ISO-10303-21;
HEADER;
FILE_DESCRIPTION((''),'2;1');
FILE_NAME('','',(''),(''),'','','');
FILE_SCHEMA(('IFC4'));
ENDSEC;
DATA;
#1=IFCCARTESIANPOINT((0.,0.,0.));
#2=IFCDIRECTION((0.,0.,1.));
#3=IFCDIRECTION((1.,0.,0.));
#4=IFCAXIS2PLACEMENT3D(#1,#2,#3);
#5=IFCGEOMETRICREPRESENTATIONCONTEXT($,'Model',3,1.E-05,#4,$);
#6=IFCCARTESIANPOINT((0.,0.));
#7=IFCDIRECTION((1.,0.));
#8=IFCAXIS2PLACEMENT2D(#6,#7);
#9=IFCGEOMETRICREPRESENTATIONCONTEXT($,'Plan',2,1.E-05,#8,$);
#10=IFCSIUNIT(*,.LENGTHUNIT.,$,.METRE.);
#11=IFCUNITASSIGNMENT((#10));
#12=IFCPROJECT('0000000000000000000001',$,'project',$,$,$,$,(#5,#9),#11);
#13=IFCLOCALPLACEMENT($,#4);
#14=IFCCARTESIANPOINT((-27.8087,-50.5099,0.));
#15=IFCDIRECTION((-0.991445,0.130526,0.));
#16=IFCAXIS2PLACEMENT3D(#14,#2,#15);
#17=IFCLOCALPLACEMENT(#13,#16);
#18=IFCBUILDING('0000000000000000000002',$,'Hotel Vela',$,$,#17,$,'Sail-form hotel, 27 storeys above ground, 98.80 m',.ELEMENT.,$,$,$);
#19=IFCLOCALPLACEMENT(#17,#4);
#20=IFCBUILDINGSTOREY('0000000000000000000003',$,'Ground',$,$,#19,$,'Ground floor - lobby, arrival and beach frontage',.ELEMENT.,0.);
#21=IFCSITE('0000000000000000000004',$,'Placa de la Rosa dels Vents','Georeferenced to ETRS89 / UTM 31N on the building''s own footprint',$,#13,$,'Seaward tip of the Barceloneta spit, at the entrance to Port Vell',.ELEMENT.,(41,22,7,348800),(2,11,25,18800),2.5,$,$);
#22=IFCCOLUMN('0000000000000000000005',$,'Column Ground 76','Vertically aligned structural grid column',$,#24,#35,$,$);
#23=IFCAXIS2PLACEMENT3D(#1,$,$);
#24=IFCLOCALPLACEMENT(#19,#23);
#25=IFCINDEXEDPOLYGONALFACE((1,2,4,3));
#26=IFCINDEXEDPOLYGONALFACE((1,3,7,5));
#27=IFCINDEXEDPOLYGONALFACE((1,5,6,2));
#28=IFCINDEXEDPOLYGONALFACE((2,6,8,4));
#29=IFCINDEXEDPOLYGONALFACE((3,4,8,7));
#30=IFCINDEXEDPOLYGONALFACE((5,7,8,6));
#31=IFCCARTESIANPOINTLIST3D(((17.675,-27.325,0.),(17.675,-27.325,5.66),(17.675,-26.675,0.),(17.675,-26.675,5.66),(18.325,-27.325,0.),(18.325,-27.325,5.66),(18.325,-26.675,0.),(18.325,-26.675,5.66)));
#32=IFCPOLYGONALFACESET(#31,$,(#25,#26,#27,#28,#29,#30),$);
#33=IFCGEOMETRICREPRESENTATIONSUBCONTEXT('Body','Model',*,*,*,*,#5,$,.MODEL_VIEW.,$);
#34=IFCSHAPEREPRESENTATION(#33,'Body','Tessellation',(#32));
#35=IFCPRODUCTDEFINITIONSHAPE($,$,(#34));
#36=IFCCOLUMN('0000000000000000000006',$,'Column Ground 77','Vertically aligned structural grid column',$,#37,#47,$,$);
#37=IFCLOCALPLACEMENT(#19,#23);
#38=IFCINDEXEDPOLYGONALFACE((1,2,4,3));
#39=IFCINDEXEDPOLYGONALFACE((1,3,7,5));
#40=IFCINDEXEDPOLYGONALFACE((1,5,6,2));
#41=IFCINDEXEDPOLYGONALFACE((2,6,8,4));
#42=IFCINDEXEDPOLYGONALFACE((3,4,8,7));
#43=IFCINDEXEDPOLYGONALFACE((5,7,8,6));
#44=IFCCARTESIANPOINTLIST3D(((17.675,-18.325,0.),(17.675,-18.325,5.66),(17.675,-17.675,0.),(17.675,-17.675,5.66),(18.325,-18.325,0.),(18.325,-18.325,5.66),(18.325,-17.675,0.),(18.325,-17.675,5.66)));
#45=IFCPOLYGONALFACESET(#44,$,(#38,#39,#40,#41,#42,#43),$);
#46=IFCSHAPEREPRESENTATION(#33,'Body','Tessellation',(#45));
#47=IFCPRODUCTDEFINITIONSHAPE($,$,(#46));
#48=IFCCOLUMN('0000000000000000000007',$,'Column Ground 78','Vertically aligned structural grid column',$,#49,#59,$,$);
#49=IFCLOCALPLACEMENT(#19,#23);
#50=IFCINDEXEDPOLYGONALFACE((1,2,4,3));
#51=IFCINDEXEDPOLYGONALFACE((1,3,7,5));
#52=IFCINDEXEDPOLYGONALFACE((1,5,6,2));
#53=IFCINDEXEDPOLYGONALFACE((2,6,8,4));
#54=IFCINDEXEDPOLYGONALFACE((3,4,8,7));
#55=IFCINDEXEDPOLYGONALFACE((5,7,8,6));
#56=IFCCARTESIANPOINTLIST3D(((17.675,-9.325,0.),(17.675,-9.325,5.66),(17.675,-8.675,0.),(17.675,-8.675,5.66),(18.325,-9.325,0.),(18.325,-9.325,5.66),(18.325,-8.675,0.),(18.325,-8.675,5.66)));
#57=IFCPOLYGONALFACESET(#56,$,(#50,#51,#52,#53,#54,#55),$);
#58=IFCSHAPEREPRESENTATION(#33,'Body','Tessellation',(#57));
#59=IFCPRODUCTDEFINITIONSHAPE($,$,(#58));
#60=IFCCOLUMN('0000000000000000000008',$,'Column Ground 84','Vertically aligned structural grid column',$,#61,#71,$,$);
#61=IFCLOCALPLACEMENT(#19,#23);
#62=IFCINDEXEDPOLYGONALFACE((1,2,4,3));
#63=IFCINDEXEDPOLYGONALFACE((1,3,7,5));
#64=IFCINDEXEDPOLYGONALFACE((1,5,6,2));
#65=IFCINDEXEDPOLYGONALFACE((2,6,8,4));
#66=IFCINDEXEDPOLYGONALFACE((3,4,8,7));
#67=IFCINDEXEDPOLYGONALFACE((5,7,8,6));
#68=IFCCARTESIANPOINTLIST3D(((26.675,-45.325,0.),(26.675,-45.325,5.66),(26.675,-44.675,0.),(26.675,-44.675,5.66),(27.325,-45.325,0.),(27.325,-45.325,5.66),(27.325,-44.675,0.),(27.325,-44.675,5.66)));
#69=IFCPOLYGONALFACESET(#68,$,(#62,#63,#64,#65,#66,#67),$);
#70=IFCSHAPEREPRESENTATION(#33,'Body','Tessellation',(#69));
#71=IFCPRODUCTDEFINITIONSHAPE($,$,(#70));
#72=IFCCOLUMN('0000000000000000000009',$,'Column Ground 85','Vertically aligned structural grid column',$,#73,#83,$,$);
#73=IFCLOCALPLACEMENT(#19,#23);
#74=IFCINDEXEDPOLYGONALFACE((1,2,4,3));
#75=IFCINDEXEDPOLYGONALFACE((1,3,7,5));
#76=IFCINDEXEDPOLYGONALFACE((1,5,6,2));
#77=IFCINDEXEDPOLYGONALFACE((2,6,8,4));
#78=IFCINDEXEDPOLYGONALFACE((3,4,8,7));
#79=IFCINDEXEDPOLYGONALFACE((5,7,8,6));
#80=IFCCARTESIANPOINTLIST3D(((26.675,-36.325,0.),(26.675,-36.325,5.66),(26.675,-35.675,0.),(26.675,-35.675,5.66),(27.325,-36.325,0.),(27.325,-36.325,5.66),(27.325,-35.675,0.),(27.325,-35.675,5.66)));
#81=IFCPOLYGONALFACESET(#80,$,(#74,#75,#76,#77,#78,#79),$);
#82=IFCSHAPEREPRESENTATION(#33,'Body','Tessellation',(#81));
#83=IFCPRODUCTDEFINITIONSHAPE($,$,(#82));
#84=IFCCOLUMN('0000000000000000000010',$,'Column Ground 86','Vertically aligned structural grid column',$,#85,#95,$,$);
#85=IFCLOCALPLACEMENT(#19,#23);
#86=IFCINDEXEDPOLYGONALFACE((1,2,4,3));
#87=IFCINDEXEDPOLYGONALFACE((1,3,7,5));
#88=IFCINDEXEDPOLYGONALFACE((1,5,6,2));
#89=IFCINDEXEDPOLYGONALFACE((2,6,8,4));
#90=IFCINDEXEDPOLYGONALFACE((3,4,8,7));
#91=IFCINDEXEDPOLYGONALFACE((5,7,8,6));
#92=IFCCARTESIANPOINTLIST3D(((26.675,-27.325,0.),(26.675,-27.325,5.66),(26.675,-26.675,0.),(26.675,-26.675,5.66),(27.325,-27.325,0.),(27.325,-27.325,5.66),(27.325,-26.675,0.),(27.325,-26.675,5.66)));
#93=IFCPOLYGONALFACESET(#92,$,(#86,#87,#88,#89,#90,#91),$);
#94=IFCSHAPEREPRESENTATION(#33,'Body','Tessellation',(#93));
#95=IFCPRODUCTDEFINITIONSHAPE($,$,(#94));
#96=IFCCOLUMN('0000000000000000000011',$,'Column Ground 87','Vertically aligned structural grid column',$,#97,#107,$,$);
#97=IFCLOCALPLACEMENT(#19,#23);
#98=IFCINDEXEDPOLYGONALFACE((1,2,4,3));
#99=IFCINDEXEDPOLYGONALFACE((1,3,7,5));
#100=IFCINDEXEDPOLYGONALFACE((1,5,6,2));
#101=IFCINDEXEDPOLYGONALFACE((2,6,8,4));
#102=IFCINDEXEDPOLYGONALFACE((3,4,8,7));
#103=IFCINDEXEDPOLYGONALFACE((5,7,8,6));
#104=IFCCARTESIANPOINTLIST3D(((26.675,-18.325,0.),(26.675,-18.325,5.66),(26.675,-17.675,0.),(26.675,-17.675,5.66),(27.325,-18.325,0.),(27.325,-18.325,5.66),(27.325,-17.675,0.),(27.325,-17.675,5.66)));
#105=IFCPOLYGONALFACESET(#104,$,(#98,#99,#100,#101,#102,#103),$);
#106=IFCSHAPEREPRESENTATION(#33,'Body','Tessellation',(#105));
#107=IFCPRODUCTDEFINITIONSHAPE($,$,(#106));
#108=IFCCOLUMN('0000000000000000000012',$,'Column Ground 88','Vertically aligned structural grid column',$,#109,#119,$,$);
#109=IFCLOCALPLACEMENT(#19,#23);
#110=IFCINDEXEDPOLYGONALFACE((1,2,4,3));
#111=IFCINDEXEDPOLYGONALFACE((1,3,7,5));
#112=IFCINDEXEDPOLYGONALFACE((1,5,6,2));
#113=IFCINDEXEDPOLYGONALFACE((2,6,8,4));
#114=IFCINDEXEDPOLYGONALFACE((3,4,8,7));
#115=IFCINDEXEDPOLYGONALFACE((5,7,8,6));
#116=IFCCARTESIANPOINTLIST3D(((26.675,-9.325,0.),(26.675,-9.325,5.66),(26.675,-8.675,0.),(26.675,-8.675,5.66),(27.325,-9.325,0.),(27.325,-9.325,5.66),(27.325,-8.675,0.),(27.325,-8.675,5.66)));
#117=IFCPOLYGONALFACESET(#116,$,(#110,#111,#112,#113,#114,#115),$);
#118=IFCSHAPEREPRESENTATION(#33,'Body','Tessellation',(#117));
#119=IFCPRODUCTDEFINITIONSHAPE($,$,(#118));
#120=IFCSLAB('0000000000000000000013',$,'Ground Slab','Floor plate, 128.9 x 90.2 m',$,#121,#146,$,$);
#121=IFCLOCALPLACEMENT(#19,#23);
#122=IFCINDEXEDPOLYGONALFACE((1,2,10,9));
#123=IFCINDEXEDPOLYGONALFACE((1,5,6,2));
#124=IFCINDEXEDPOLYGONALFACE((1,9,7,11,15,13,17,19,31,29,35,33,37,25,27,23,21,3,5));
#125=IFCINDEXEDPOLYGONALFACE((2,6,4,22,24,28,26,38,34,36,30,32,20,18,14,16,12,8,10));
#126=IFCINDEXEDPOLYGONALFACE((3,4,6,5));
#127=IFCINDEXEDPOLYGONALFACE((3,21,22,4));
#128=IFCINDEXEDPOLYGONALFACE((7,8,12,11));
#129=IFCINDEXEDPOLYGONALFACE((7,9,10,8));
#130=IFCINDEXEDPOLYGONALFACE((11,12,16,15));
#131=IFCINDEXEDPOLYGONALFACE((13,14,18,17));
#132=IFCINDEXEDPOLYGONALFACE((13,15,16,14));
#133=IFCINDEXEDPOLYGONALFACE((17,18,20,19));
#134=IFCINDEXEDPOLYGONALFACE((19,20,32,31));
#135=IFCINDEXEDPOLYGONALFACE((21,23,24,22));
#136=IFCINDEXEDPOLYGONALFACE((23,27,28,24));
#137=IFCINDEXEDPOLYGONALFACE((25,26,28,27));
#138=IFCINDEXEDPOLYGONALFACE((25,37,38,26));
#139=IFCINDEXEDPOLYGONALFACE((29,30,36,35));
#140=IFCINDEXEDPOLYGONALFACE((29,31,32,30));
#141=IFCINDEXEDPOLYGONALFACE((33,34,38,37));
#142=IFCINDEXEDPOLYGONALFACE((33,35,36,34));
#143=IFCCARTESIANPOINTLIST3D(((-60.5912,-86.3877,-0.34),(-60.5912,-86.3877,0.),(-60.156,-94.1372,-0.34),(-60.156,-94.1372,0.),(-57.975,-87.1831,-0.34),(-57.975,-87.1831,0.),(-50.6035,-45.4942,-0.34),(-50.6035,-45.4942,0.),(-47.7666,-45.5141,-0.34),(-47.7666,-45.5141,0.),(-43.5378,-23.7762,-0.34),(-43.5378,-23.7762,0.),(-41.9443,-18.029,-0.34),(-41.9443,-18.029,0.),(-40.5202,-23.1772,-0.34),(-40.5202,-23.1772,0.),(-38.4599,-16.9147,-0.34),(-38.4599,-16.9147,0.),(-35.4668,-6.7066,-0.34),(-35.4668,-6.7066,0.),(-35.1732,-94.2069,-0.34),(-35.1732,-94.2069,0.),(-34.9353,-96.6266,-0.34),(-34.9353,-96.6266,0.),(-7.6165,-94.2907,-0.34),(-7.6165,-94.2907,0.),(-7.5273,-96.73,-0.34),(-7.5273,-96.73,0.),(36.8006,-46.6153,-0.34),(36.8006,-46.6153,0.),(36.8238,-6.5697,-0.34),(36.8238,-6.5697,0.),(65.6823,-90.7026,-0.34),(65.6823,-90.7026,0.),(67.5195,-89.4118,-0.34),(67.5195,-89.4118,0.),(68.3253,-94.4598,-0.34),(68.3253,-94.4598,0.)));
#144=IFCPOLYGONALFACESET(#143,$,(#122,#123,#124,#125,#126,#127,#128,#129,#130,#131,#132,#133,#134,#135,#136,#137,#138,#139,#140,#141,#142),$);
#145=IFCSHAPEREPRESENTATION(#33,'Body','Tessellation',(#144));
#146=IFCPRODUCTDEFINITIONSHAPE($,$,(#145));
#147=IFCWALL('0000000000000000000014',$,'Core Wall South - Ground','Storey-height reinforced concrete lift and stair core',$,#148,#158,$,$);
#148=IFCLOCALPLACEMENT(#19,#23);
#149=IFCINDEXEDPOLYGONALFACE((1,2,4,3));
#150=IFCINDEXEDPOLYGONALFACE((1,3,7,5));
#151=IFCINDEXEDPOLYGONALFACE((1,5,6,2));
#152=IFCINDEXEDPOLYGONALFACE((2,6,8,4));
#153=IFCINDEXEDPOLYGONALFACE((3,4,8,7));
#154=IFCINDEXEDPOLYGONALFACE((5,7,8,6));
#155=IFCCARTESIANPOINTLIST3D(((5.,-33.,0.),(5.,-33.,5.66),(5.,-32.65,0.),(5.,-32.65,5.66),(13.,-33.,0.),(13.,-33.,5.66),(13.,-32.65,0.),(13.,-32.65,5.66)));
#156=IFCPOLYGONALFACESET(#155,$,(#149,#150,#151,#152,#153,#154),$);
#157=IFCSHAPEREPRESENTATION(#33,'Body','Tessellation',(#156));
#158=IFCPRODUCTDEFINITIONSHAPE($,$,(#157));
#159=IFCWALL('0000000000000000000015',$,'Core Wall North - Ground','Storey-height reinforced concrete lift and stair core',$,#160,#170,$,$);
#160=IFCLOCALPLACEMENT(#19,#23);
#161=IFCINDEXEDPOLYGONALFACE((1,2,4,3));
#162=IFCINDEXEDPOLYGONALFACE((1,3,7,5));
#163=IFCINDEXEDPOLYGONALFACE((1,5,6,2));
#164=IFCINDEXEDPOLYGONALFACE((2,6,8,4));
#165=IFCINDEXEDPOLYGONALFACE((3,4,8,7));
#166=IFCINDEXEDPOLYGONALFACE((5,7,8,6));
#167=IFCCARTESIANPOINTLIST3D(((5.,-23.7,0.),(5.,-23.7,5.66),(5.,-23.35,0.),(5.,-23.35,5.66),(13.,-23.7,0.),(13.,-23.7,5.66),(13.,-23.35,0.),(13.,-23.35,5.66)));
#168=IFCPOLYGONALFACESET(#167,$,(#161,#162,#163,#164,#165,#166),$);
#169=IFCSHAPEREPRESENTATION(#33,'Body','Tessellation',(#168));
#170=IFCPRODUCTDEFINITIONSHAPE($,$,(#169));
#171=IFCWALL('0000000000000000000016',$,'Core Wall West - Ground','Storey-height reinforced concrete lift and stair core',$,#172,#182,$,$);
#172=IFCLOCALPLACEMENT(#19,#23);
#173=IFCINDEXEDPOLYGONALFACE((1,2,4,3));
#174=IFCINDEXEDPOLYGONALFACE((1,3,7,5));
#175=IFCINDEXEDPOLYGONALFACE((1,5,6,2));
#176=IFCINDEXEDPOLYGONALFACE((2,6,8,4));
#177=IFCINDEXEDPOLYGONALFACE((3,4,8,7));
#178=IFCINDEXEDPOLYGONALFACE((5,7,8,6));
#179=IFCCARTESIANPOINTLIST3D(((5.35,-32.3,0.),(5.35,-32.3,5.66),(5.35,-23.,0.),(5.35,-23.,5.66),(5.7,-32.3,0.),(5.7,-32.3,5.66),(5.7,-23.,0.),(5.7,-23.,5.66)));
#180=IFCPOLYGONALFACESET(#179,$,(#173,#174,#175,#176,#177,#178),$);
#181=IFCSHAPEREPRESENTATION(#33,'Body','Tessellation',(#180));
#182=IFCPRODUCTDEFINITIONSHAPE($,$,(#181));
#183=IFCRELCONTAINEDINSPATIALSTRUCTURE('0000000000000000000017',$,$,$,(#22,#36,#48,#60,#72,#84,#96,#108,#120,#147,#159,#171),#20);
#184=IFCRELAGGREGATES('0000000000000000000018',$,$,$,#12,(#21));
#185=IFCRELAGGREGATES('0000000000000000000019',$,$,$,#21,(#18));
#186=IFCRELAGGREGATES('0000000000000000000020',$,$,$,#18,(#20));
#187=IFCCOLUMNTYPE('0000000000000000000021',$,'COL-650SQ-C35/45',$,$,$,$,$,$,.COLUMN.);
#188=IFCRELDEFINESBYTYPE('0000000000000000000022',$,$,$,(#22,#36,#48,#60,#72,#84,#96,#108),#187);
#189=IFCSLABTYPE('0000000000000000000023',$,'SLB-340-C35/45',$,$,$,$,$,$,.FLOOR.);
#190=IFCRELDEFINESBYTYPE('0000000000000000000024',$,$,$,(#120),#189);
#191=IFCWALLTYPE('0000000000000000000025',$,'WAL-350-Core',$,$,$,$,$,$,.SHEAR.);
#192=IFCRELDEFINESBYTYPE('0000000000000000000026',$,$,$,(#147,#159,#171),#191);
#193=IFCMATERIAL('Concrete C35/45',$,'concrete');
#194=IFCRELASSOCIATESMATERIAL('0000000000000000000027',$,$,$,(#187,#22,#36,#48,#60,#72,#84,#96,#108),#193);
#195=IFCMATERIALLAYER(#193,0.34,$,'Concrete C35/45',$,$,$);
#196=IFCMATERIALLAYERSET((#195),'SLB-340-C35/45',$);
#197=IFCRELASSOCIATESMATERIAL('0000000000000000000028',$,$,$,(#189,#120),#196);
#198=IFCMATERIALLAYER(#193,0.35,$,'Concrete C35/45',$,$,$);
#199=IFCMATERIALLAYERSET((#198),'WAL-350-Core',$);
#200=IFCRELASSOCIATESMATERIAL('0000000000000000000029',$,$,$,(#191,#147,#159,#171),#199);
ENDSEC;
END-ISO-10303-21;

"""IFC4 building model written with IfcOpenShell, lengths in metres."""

from ifc_helpers import new_model, si_unit, frame, origin_with_axes, origin_2d_with_axis, place, context, subcontext, project, spatial, line, indexed_curve, rectangle, outline, extrude, material, layer, layer_set, layer_usage, material_profile, profile_set, profile_usage, type_object, element, save


model = new_model("IFC4")

# Units and contexts
model_context = context("Model", 3, precision=1e-05, world=origin_with_axes())
plan_context = context("Plan", 2, precision=1e-05, world=origin_2d_with_axis())
body_context = subcontext(model_context, "Body", "Model", "MODEL_VIEW")
ifc_project = project(units=[si_unit("LENGTHUNIT", "METRE")], contexts=[model_context, plan_context])

# Site, building, storey
site_placement = place(None, origin_with_axes())
site = spatial("IfcSite", under=ifc_project, at=site_placement, Name="Placa de la Rosa dels Vents", Description="Georeferenced to ETRS89 / UTM 31N on the building's own footprint", LongName="Seaward tip of the Barceloneta spit, at the entrance to Port Vell", CompositionType="ELEMENT", RefLatitude=(41, 22, 7, 348800), RefLongitude=(2, 11, 25, 18800), RefElevation=2.5)
building_placement = place(site_placement, frame((-27.8087, -50.5099, 0.0), z_axis=(0.0, 0.0, 1.0), x_axis=(-0.991445, 0.130526, 0.0)))
building = spatial("IfcBuilding", under=site, at=building_placement, Name="Hotel Vela", LongName="Sail-form hotel, 27 storeys above ground, 98.80 m", CompositionType="ELEMENT")
storey_placement = place(building_placement, origin_with_axes())
storey = spatial("IfcBuildingStorey", under=building, at=storey_placement, Name="Ground", LongName="Ground floor - lobby, arrival and beach frontage", CompositionType="ELEMENT", Elevation=0.0)

# Columns
ifc_material = material(Name="Concrete C35/45", Category="concrete")
ifc_material_profile = material_profile(ifc_material, rectangle(XDim=0.65, YDim=0.65))
ifc_profile_set = profile_set([ifc_material_profile], Name="COL-650SQ-C35/45")
column_type = type_object("IfcColumnType", Name="COL-650SQ-C35/45", PredefinedType="COLUMN", material=ifc_profile_set)
ifc_profile_usage_1 = profile_usage(ifc_profile_set)
column_1_placement = place(storey_placement, frame((17.675, -27.325, 0.0), z_axis=(0.0, 0.0, 1.0), x_axis=(1.0, 0.0, 0.0)))
element("IfcColumn", 1, at=column_1_placement, inside=storey, type_object=column_type, material=ifc_profile_usage_1, Name="Column Ground 76", Description="Vertically aligned structural grid column", context=body_context, shape_type="SweptSolid", body=[
    extrude(outline(indexed_curve([(0.0, 0.0), (0.65, 0.0), (0.65, 0.65), (0.0, 0.65)], segments=[line(1, 2, 3, 4, 1)])), origin_with_axes(), (0.0, 0.0, 1.0), 5.66),
])
ifc_profile_usage_2 = profile_usage(ifc_profile_set)
column_2_placement = place(storey_placement, frame((17.675, -18.325, 0.0), z_axis=(0.0, 0.0, 1.0), x_axis=(1.0, 0.0, 0.0)))
element("IfcColumn", 2, at=column_2_placement, inside=storey, type_object=column_type, material=ifc_profile_usage_2, Name="Column Ground 77", Description="Vertically aligned structural grid column", context=body_context, shape_type="SweptSolid", body=[
    extrude(outline(indexed_curve([(0.0, 0.0), (0.65, 0.0), (0.65, 0.65), (0.0, 0.65)], segments=[line(1, 2, 3, 4, 1)])), origin_with_axes(), (0.0, 0.0, 1.0), 5.66),
])
ifc_profile_usage_3 = profile_usage(ifc_profile_set)
column_3_placement = place(storey_placement, frame((17.675, -9.325, 0.0), z_axis=(0.0, 0.0, 1.0), x_axis=(1.0, 0.0, 0.0)))
element("IfcColumn", 3, at=column_3_placement, inside=storey, type_object=column_type, material=ifc_profile_usage_3, Name="Column Ground 78", Description="Vertically aligned structural grid column", context=body_context, shape_type="SweptSolid", body=[
    extrude(outline(indexed_curve([(0.0, 0.0), (0.65, 0.0), (0.65, 0.65), (0.0, 0.65)], segments=[line(1, 2, 3, 4, 1)])), origin_with_axes(), (0.0, 0.0, 1.0), 5.66),
])
ifc_profile_usage_4 = profile_usage(ifc_profile_set)
column_4_placement = place(storey_placement, frame((26.675, -45.325, 0.0), z_axis=(0.0, 0.0, 1.0), x_axis=(1.0, 0.0, 0.0)))
element("IfcColumn", 4, at=column_4_placement, inside=storey, type_object=column_type, material=ifc_profile_usage_4, Name="Column Ground 84", Description="Vertically aligned structural grid column", context=body_context, shape_type="SweptSolid", body=[
    extrude(outline(indexed_curve([(0.0, 0.0), (0.65, 0.0), (0.65, 0.65), (0.0, 0.65)], segments=[line(1, 2, 3, 4, 1)])), origin_with_axes(), (0.0, 0.0, 1.0), 5.66),
])
ifc_profile_usage_5 = profile_usage(ifc_profile_set)
column_5_placement = place(storey_placement, frame((26.675, -36.325, 0.0), z_axis=(0.0, 0.0, 1.0), x_axis=(1.0, 0.0, 0.0)))
element("IfcColumn", 5, at=column_5_placement, inside=storey, type_object=column_type, material=ifc_profile_usage_5, Name="Column Ground 85", Description="Vertically aligned structural grid column", context=body_context, shape_type="SweptSolid", body=[
    extrude(outline(indexed_curve([(0.0, 0.0), (0.65, 0.0), (0.65, 0.65), (0.0, 0.65)], segments=[line(1, 2, 3, 4, 1)])), origin_with_axes(), (0.0, 0.0, 1.0), 5.66),
])
ifc_profile_usage_6 = profile_usage(ifc_profile_set)
column_6_placement = place(storey_placement, frame((26.675, -27.325, 0.0), z_axis=(0.0, 0.0, 1.0), x_axis=(1.0, 0.0, 0.0)))
element("IfcColumn", 6, at=column_6_placement, inside=storey, type_object=column_type, material=ifc_profile_usage_6, Name="Column Ground 86", Description="Vertically aligned structural grid column", context=body_context, shape_type="SweptSolid", body=[
    extrude(outline(indexed_curve([(0.0, 0.0), (0.65, 0.0), (0.65, 0.65), (0.0, 0.65)], segments=[line(1, 2, 3, 4, 1)])), origin_with_axes(), (0.0, 0.0, 1.0), 5.66),
])
ifc_profile_usage_7 = profile_usage(ifc_profile_set)
column_7_placement = place(storey_placement, frame((26.675, -18.325, 0.0), z_axis=(0.0, 0.0, 1.0), x_axis=(1.0, 0.0, 0.0)))
element("IfcColumn", 7, at=column_7_placement, inside=storey, type_object=column_type, material=ifc_profile_usage_7, Name="Column Ground 87", Description="Vertically aligned structural grid column", context=body_context, shape_type="SweptSolid", body=[
    extrude(outline(indexed_curve([(0.0, 0.0), (0.65, 0.0), (0.65, 0.65), (0.0, 0.65)], segments=[line(1, 2, 3, 4, 1)])), origin_with_axes(), (0.0, 0.0, 1.0), 5.66),
])
ifc_profile_usage_8 = profile_usage(ifc_profile_set)
column_8_placement = place(storey_placement, frame((26.675, -9.325, 0.0), z_axis=(0.0, 0.0, 1.0), x_axis=(1.0, 0.0, 0.0)))
element("IfcColumn", 8, at=column_8_placement, inside=storey, type_object=column_type, material=ifc_profile_usage_8, Name="Column Ground 88", Description="Vertically aligned structural grid column", context=body_context, shape_type="SweptSolid", body=[
    extrude(outline(indexed_curve([(0.0, 0.0), (0.65, 0.0), (0.65, 0.65), (0.0, 0.65)], segments=[line(1, 2, 3, 4, 1)])), origin_with_axes(), (0.0, 0.0, 1.0), 5.66),
])

# Slab
ifc_layer_1 = layer(ifc_material, 0.34, Name="Concrete C35/45")
ifc_layer_set_1 = layer_set([ifc_layer_1], Name="SLB-340-C35/45")
ifc_layer_usage_1 = layer_usage(ifc_layer_set_1, "AXIS3", "POSITIVE", 0.0)
slab_type = type_object("IfcSlabType", Name="SLB-340-C35/45", PredefinedType="FLOOR", material=ifc_layer_set_1)
slab_placement = place(storey_placement, frame((0.0, 0.0, -0.34), z_axis=(0.0, 0.0, 1.0), x_axis=(1.0, 0.0, 0.0)))
element("IfcSlab", 9, at=slab_placement, inside=storey, type_object=slab_type, material=ifc_layer_usage_1, Name="Ground Slab", Description="Floor plate, 128.9 x 90.2 m", context=body_context, shape_type="SweptSolid", body=[
    extrude(outline(indexed_curve([(-60.156, -94.1372), (-35.1732, -94.2069), (-34.9353, -96.6266), (-7.5273, -96.73), (-7.6165, -94.2907), (68.3253, -94.4598), (65.6823, -90.7026), (67.5195, -89.4118), (36.8006, -46.6153), (36.8238, -6.5697), (-35.4668, -6.7066), (-38.4599, -16.9147), (-41.9443, -18.029), (-40.5202, -23.1772), (-43.5378, -23.7762), (-50.6035, -45.4942), (-47.7666, -45.5141), (-60.5912, -86.3877), (-57.975, -87.1831)], segments=[line(1, 2, 3, 4, 5, 6, 7, 8, 9, 10, 11, 12, 13, 14, 15, 16, 17, 18, 19, 1)])), origin_with_axes(), (0.0, 0.0, 1.0), 0.34),
])

# Walls
ifc_layer_2 = layer(ifc_material, 0.35, Name="Concrete C35/45")
ifc_layer_set_2 = layer_set([ifc_layer_2], Name="WAL-350-Core")
ifc_layer_usage_2 = layer_usage(ifc_layer_set_2, "AXIS2", "POSITIVE", 0.0)
wall_type = type_object("IfcWallType", Name="WAL-350-Core", PredefinedType="SHEAR", material=ifc_layer_set_2)
wall_1_placement = place(storey_placement, frame((5.0, -33.0, 0.0), z_axis=(0.0, 0.0, 1.0), x_axis=(1.0, 0.0, 0.0)))
element("IfcWall", 10, at=wall_1_placement, inside=storey, type_object=wall_type, material=ifc_layer_usage_2, Name="Core Wall South - Ground", Description="Storey-height reinforced concrete lift and stair core", context=body_context, shape_type="SweptSolid", body=[
    extrude(outline(indexed_curve([(0.0, 0.0), (8.0, 0.0), (8.0, 0.35), (0.0, 0.35)], segments=[line(1, 2, 3, 4, 1)])), origin_with_axes(), (0.0, 0.0, 1.0), 5.66),
])
ifc_layer_usage_3 = layer_usage(ifc_layer_set_2, "AXIS2", "POSITIVE", 0.0)
wall_2_placement = place(storey_placement, frame((13.0, -23.35, 0.0), z_axis=(0.0, 0.0, 1.0), x_axis=(-1.0, 0.0, 0.0)))
element("IfcWall", 11, at=wall_2_placement, inside=storey, type_object=wall_type, material=ifc_layer_usage_3, Name="Core Wall North - Ground", Description="Storey-height reinforced concrete lift and stair core", context=body_context, shape_type="SweptSolid", body=[
    extrude(outline(indexed_curve([(0.0, 0.0), (8.0, 0.0), (8.0, 0.35), (0.0, 0.35)], segments=[line(1, 2, 3, 4, 1)])), origin_with_axes(), (0.0, 0.0, 1.0), 5.66),
])
ifc_layer_usage_4 = layer_usage(ifc_layer_set_2, "AXIS2", "POSITIVE", 0.0)
wall_3_placement = place(storey_placement, frame((5.35, -23.0, 0.0), z_axis=(0.0, 0.0, 1.0), x_axis=(0.0, -1.0, 0.0)))
element("IfcWall", 12, at=wall_3_placement, inside=storey, type_object=wall_type, material=ifc_layer_usage_4, Name="Core Wall West - Ground", Description="Storey-height reinforced concrete lift and stair core", context=body_context, shape_type="SweptSolid", body=[
    extrude(outline(indexed_curve([(0.0, 0.0), (9.3, 0.0), (9.3, 0.35), (0.0, 0.35)], segments=[line(1, 2, 3, 4, 1)])), origin_with_axes(), (0.0, 0.0, 1.0), 5.66),
])

save(model, "model.ifc")
